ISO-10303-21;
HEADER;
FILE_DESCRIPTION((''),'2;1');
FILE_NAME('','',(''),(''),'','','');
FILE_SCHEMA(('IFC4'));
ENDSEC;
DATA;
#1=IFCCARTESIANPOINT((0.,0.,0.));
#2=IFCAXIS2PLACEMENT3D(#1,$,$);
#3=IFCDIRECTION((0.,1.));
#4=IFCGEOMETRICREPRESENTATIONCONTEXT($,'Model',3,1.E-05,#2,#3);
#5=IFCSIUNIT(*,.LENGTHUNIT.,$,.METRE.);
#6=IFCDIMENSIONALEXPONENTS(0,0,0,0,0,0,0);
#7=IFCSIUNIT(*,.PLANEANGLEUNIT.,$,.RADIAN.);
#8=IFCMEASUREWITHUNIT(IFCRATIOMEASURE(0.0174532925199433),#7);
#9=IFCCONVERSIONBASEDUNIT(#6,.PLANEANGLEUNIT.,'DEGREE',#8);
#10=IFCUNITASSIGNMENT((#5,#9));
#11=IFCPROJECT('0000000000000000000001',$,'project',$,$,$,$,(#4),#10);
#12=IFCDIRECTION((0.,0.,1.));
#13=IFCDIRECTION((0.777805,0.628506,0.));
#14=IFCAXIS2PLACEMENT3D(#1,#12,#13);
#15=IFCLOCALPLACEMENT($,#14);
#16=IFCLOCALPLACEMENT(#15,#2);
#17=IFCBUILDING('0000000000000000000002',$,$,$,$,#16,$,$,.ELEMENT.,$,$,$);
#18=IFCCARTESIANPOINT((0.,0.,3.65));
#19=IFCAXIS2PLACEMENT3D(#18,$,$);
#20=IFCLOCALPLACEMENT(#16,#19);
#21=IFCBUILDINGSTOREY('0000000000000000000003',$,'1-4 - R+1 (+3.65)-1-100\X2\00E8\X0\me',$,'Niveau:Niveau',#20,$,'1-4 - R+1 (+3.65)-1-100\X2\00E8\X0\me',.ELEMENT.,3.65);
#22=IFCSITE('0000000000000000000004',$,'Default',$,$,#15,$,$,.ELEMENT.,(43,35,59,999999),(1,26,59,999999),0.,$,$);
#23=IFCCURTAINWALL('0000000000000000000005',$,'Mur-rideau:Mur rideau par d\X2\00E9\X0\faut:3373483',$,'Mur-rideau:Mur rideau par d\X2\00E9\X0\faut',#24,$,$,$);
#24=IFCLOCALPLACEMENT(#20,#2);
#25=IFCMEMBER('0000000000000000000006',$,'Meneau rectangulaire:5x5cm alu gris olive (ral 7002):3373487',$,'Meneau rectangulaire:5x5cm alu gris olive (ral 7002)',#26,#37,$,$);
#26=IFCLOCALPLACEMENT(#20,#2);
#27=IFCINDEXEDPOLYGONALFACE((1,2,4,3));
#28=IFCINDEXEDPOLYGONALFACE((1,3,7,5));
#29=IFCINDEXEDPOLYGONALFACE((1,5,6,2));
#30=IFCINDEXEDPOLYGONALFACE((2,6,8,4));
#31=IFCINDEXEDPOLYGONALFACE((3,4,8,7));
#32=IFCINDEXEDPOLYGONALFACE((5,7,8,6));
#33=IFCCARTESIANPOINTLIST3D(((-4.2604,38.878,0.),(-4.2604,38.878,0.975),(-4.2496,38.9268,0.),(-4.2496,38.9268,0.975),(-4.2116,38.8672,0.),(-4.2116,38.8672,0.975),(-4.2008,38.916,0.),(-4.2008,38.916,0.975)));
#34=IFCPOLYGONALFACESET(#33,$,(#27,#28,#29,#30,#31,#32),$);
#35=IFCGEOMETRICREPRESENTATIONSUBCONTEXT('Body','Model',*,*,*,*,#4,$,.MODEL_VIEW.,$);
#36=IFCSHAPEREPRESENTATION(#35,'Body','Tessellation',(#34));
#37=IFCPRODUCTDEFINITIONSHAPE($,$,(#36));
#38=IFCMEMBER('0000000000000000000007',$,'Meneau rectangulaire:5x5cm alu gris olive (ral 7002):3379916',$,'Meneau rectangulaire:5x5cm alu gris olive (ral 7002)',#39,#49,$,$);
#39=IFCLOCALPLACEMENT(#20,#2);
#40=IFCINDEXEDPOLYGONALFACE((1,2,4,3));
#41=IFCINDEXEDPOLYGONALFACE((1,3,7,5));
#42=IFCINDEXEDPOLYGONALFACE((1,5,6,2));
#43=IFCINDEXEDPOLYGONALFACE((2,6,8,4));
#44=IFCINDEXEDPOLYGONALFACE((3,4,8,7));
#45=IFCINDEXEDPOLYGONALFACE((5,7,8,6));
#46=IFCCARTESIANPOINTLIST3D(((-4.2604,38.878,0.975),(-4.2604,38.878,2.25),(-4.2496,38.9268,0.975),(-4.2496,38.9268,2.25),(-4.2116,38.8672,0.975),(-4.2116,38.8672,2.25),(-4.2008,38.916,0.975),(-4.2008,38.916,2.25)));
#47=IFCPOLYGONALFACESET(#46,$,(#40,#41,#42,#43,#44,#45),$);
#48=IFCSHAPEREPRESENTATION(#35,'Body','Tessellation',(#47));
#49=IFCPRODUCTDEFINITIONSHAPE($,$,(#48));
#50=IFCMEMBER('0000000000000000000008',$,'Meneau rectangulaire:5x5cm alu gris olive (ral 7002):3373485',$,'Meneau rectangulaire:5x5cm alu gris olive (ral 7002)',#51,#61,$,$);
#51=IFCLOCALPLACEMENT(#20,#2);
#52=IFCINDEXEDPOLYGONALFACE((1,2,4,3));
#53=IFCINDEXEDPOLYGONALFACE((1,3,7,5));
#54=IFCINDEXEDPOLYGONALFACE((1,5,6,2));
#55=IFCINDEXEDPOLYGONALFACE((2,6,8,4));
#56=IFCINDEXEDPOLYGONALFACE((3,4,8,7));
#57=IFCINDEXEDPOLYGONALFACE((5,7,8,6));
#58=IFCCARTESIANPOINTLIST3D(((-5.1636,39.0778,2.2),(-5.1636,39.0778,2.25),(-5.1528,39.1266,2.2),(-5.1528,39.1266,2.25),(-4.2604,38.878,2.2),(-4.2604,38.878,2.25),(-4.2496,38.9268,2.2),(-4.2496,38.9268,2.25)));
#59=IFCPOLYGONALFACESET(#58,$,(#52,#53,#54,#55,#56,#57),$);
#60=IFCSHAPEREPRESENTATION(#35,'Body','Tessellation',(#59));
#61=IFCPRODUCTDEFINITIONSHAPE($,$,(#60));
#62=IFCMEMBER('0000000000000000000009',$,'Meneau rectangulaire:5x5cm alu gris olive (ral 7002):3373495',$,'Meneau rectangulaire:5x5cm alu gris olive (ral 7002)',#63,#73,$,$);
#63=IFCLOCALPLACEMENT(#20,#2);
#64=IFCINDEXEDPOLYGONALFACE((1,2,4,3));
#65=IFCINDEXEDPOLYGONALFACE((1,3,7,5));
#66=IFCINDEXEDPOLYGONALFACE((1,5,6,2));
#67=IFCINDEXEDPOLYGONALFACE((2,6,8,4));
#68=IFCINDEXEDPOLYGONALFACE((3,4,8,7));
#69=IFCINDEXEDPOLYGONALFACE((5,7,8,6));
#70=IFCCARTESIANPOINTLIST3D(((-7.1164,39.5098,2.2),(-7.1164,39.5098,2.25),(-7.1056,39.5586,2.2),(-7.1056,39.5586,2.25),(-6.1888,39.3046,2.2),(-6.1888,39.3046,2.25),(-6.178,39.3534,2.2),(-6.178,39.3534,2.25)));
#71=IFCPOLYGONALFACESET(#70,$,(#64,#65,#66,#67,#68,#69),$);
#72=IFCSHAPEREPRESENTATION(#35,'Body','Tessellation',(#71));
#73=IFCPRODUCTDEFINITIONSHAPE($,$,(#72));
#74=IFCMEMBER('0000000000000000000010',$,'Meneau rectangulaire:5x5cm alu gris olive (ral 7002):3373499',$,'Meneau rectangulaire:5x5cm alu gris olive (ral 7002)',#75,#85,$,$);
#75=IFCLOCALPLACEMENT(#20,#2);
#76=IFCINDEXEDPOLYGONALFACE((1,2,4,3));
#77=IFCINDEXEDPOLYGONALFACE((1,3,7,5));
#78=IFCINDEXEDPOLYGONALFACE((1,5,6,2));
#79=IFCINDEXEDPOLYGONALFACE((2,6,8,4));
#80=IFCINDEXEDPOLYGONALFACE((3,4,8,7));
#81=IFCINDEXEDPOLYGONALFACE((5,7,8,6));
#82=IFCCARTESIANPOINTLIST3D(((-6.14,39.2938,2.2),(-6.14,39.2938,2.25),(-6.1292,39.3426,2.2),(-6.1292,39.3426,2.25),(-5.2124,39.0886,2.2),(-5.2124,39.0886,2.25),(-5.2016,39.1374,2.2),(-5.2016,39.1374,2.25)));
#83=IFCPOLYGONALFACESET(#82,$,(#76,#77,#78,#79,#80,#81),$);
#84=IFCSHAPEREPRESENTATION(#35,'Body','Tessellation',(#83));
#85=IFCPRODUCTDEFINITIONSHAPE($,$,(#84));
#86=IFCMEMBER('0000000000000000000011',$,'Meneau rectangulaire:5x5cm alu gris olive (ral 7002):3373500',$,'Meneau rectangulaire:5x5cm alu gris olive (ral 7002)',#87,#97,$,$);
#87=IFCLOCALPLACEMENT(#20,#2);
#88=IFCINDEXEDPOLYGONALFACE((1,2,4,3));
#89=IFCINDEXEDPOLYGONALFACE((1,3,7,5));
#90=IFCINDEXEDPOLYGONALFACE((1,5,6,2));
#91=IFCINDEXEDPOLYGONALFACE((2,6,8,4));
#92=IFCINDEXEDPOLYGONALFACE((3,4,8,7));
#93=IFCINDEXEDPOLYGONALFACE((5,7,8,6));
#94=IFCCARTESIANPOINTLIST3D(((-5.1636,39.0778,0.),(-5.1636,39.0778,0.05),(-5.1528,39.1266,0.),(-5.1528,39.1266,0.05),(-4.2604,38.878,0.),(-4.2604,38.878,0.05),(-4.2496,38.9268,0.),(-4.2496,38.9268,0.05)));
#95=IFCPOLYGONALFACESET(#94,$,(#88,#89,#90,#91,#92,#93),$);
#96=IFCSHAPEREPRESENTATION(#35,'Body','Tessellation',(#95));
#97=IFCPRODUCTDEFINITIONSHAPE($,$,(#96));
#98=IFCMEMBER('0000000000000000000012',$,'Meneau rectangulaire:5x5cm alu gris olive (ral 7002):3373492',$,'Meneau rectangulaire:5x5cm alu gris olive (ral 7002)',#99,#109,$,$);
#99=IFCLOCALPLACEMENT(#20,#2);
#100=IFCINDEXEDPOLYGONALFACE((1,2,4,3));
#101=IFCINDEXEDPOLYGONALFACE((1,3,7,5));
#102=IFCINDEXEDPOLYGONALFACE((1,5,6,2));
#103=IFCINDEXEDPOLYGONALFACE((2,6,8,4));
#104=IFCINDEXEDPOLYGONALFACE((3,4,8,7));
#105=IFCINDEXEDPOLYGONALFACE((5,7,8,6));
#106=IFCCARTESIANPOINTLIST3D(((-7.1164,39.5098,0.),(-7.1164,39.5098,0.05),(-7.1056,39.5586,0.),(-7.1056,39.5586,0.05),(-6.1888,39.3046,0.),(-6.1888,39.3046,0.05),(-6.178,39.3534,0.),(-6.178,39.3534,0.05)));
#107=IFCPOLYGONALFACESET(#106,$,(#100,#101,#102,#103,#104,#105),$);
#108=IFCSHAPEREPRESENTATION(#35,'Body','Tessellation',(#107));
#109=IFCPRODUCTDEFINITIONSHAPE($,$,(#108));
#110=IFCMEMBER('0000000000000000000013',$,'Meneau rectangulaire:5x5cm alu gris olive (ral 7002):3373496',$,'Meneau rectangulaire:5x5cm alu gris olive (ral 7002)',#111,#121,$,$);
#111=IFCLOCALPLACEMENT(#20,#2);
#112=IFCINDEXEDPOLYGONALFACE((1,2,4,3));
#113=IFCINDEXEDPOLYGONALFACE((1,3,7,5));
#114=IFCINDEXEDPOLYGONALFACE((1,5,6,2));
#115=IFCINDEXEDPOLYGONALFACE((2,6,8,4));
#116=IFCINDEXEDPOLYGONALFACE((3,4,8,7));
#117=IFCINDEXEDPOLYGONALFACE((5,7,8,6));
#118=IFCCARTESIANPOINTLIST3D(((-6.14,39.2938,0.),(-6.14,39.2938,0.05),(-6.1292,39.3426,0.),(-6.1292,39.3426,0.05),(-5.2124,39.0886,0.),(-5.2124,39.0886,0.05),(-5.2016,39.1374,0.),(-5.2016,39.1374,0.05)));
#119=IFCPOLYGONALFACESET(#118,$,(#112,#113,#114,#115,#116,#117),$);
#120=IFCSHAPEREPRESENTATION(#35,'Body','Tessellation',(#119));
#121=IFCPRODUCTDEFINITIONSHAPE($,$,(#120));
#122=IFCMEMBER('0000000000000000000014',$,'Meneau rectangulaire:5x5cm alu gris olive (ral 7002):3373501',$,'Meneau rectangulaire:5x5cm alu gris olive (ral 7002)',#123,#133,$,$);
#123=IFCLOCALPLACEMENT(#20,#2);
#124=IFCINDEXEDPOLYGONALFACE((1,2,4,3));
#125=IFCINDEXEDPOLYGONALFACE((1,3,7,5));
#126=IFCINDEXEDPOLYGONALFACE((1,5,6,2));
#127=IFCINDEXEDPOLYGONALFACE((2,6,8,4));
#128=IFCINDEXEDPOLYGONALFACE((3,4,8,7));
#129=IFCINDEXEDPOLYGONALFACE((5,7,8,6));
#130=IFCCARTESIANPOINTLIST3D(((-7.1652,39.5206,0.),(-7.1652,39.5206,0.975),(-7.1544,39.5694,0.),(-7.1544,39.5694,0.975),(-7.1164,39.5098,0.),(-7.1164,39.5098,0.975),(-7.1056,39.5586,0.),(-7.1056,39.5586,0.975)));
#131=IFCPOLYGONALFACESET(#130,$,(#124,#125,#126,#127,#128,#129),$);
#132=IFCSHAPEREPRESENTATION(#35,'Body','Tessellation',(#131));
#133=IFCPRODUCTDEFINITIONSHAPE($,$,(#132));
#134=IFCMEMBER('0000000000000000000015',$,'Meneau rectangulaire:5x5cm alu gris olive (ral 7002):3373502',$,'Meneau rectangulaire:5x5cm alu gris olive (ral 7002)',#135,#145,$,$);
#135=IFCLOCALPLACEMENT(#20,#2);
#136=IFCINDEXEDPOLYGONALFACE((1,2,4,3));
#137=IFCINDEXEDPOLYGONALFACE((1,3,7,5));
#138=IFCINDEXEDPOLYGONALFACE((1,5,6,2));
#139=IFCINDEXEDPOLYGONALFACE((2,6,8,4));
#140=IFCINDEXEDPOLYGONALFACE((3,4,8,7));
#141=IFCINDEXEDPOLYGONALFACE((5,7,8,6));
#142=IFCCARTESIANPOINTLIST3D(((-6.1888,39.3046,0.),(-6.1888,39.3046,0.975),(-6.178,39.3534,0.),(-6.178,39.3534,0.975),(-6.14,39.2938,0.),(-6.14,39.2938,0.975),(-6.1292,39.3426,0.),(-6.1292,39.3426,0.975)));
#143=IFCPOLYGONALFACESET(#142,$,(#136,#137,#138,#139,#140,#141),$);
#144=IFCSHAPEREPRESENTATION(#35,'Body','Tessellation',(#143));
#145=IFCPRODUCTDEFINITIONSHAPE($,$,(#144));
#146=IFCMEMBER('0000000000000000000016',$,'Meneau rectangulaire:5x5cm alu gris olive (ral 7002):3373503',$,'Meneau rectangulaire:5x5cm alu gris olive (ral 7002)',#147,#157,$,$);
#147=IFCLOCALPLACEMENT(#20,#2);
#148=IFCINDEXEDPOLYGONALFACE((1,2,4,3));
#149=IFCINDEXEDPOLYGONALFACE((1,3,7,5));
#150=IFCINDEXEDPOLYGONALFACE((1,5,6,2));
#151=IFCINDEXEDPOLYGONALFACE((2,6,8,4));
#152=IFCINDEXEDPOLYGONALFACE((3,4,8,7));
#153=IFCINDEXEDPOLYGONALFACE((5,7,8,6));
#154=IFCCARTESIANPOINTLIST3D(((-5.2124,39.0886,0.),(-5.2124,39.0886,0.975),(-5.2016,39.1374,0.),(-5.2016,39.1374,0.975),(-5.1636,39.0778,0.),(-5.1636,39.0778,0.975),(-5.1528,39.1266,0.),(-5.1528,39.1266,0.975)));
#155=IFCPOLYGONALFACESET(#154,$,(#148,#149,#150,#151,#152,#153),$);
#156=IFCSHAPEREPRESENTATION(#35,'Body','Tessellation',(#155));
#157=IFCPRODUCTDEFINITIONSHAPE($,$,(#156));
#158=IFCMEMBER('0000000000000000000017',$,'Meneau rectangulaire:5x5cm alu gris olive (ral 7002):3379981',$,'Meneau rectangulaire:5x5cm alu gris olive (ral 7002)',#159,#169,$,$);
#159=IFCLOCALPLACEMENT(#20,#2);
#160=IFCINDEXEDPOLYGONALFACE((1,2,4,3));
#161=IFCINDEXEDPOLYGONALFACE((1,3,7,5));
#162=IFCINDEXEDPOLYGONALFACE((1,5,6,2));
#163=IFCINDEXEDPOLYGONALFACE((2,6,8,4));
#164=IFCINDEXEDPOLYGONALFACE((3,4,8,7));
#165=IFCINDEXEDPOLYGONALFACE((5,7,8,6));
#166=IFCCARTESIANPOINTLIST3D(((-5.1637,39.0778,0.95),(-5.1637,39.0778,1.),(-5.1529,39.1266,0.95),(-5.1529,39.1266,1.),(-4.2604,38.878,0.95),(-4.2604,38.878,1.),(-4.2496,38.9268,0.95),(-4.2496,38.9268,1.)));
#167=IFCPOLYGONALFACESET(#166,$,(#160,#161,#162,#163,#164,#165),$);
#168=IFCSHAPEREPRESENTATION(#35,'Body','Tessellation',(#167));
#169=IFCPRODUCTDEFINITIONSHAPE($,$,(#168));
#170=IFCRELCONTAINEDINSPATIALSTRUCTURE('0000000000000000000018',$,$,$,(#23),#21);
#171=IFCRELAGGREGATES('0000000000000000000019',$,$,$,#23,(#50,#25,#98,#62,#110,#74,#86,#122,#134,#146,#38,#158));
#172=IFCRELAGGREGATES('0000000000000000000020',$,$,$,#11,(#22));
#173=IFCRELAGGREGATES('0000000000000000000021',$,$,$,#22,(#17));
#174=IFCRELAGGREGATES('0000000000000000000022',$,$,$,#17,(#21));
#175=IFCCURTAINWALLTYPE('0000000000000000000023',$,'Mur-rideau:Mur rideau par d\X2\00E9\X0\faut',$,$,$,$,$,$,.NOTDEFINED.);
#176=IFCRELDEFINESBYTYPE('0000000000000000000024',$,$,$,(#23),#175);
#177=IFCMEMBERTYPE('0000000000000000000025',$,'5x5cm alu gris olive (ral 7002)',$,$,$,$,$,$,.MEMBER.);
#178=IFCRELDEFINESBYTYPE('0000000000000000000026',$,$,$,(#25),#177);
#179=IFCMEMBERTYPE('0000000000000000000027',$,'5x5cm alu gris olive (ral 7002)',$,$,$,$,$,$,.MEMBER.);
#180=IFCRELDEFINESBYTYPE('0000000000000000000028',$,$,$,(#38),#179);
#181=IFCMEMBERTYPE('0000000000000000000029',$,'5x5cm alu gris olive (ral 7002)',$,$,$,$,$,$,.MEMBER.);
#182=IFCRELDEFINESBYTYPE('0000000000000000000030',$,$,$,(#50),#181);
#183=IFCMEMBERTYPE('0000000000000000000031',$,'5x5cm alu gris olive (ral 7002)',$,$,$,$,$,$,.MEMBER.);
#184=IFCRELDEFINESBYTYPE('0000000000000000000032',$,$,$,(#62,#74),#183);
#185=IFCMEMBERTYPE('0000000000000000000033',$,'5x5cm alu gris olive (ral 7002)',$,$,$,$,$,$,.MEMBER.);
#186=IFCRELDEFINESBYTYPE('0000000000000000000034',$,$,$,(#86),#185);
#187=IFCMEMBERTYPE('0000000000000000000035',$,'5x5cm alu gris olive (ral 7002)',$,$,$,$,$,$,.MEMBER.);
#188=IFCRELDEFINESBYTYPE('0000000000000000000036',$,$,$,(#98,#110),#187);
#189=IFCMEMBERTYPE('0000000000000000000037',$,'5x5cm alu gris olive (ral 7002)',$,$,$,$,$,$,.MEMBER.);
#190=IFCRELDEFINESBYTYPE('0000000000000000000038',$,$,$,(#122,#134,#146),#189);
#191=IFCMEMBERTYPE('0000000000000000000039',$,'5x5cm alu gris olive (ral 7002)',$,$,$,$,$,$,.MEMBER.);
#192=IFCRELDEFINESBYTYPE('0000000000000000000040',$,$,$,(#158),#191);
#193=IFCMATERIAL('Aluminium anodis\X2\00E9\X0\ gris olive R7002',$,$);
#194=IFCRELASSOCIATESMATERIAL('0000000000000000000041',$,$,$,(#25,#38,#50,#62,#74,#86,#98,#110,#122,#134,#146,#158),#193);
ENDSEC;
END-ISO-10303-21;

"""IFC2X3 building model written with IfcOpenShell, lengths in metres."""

from ifc_helpers import new_model, entity, si_unit, converted_unit, direction, frame, origin, origin_2d_with_axis, place, context, subcontext, project, spatial, rectangle, extrude, source, transform, mapped, material, type_object, type_shapes, element, aggregate, save


model = new_model("IFC2X3")

# Units and contexts
model_context = context("Model", 3, precision=1e-05, world=origin(), true_north=direction((0.0, 1.0)))
body_context = subcontext(model_context, "Body", "Model", "MODEL_VIEW")
ifc_project = project(units=[si_unit("LENGTHUNIT", "METRE"), converted_unit("PLANEANGLEUNIT", "DEGREE", entity("IfcRatioMeasure", 0.0174532925199433), si_unit("PLANEANGLEUNIT", "RADIAN"), dimensions=[0, 0, 0, 0, 0, 0, 0])], contexts=[model_context])

# Site, building, storey
site_placement = place(None, frame((0.0, 0.0, 0.0), z_axis=(0.0, 0.0, 1.0), x_axis=(0.777805, 0.628506, 0.0)))
site = spatial("IfcSite", under=ifc_project, at=site_placement, Name="Default", CompositionType="ELEMENT", RefLatitude=(43, 35, 59, 999999), RefLongitude=(1, 26, 59, 999999), RefElevation=0.0)
building_placement = place(site_placement, origin())
building = spatial("IfcBuilding", under=site, at=building_placement, CompositionType="ELEMENT")
storey_placement = place(building_placement, frame((0.0, 0.0, 3.65)))
storey = spatial("IfcBuildingStorey", under=building, at=storey_placement, Name="1-4 - R+1 (+3.65)-1-100ème", ObjectType="Niveau:Niveau", LongName="1-4 - R+1 (+3.65)-1-100ème", CompositionType="ELEMENT", Elevation=3.65)

# Curtain wall, members
curtain_wall_type = type_object("IfcCurtainWallType", Name="Mur-rideau:Mur rideau par défaut", PredefinedType="NOTDEFINED")
curtain_wall_placement = place(storey_placement, frame((0.0, 0.0, -3.65)))
curtain_wall = element("IfcCurtainWall", 1, at=curtain_wall_placement, inside=storey, type_object=curtain_wall_type, Name="Mur-rideau:Mur rideau par défaut:3373483", ObjectType="Mur-rideau:Mur rideau par défaut")
ifc_material_1 = material(Name="Aluminium anodisé gris olive R7002")
member_type_1 = type_object("IfcMemberType", Name="5x5cm alu gris olive (ral 7002)", PredefinedType="MEMBER")
shared_shape_1 = source(origin(), body_context, "Body", "SweptSolid", [
    extrude(rectangle(XDim=0.05, YDim=0.05, at=origin_2d_with_axis()), frame((-0.025, 0.0, -0.975), z_axis=(0.0, 0.0, 1.0), x_axis=(0.0, -1.0, 0.0)), (0.0, 0.0, 1.0), 0.975),
])
type_shapes(member_type_1, [shared_shape_1])
member_1_placement = place(storey_placement, frame((-4.2062, 38.8916, 0.0), z_axis=(0.0, 0.0, -1.0), x_axis=(0.976392, -0.216005, 0.0)))
member_1 = element("IfcMember", 2, at=member_1_placement, type_object=member_type_1, material=ifc_material_1, Name="Meneau rectangulaire:5x5cm alu gris olive (ral 7002):3373487", ObjectType="Meneau rectangulaire:5x5cm alu gris olive (ral 7002)", context=body_context, shape_type="MappedRepresentation", body=[
    mapped(shared_shape_1, transform((0.0, 0.0, 0.0), scale=1.0)),
])
member_type_2 = type_object("IfcMemberType", Name="5x5cm alu gris olive (ral 7002)", PredefinedType="MEMBER")
shared_shape_2 = source(origin(), body_context, "Body", "SweptSolid", [
    extrude(rectangle(XDim=0.05, YDim=0.05, at=origin_2d_with_axis()), frame((-0.025, 0.0, -1.275), z_axis=(0.0, 0.0, 1.0), x_axis=(0.0, -1.0, 0.0)), (0.0, 0.0, 1.0), 1.275),
])
type_shapes(member_type_2, [shared_shape_2])
member_2_placement = place(storey_placement, frame((-4.2062, 38.8916, 0.975), z_axis=(0.0, 0.0, -1.0), x_axis=(0.976392, -0.216005, 0.0)))
member_2 = element("IfcMember", 3, at=member_2_placement, type_object=member_type_2, material=ifc_material_1, Name="Meneau rectangulaire:5x5cm alu gris olive (ral 7002):3379916", ObjectType="Meneau rectangulaire:5x5cm alu gris olive (ral 7002)", context=body_context, shape_type="MappedRepresentation", body=[
    mapped(shared_shape_2, transform((0.0, 0.0, 0.0), scale=1.0)),
])
member_type_3 = type_object("IfcMemberType", Name="5x5cm alu gris olive (ral 7002)", PredefinedType="MEMBER")
shared_shape_3 = source(origin(), body_context, "Body", "SweptSolid", [
    extrude(rectangle(XDim=0.05, YDim=0.05, at=origin_2d_with_axis()), frame((-0.025, 0.0, -0.925), z_axis=(0.0, 0.0, 1.0), x_axis=(0.0, -1.0, 0.0)), (0.0, 0.0, 1.0), 0.925),
])
type_shapes(member_type_3, [shared_shape_3])
member_3_placement = place(storey_placement, frame((-4.255, 38.9024, 2.25), z_axis=(0.976392, -0.216005, 0.0), x_axis=(0.0, 0.0, 1.0)))
member_3 = element("IfcMember", 4, at=member_3_placement, type_object=member_type_3, material=ifc_material_1, Name="Meneau rectangulaire:5x5cm alu gris olive (ral 7002):3373485", ObjectType="Meneau rectangulaire:5x5cm alu gris olive (ral 7002)", context=body_context, shape_type="MappedRepresentation", body=[
    mapped(shared_shape_3, transform((0.0, 0.0, 0.0), scale=1.0)),
])
member_type_4 = type_object("IfcMemberType", Name="5x5cm alu gris olive (ral 7002)", PredefinedType="MEMBER")
shared_shape_4 = source(origin(), body_context, "Body", "SweptSolid", [
    extrude(rectangle(XDim=0.05, YDim=0.05, at=origin_2d_with_axis()), frame((-0.025, 0.0, -0.95), z_axis=(0.0, 0.0, 1.0), x_axis=(0.0, -1.0, 0.0)), (0.0, 0.0, 1.0), 0.95),
])
type_shapes(member_type_4, [shared_shape_4])
member_4_placement = place(storey_placement, frame((-6.1834, 39.329, 2.25), z_axis=(0.976392, -0.216005, 0.0), x_axis=(0.0, 0.0, 1.0)))
member_4 = element("IfcMember", 5, at=member_4_placement, type_object=member_type_4, material=ifc_material_1, Name="Meneau rectangulaire:5x5cm alu gris olive (ral 7002):3373495", ObjectType="Meneau rectangulaire:5x5cm alu gris olive (ral 7002)", context=body_context, shape_type="MappedRepresentation", body=[
    mapped(shared_shape_4, transform((0.0, 0.0, 0.0), scale=1.0)),
])
member_5_placement = place(storey_placement, frame((-5.207, 39.113, 2.25), z_axis=(0.976392, -0.216005, 0.0), x_axis=(0.0, 0.0, 1.0)))
member_5 = element("IfcMember", 6, at=member_5_placement, type_object=member_type_4, material=ifc_material_1, Name="Meneau rectangulaire:5x5cm alu gris olive (ral 7002):3373499", ObjectType="Meneau rectangulaire:5x5cm alu gris olive (ral 7002)", context=body_context, shape_type="MappedRepresentation", body=[
    mapped(shared_shape_4, transform((0.0, 0.0, 0.0), scale=1.0)),
])
member_type_5 = type_object("IfcMemberType", Name="5x5cm alu gris olive (ral 7002)", PredefinedType="MEMBER")
shared_shape_5 = source(origin(), body_context, "Body", "SweptSolid", [
    extrude(rectangle(XDim=0.05, YDim=0.05, at=origin_2d_with_axis()), frame((-0.025, 0.0, -0.925), z_axis=(0.0, 0.0, 1.0), x_axis=(0.0, -1.0, 0.0)), (0.0, 0.0, 1.0), 0.925),
])
type_shapes(member_type_5, [shared_shape_5])
member_6_placement = place(storey_placement, frame((-5.1582, 39.1022, 0.0), z_axis=(-0.976392, 0.216005, 0.0), x_axis=(0.0, 0.0, -1.0)))
member_6 = element("IfcMember", 7, at=member_6_placement, type_object=member_type_5, material=ifc_material_1, Name="Meneau rectangulaire:5x5cm alu gris olive (ral 7002):3373500", ObjectType="Meneau rectangulaire:5x5cm alu gris olive (ral 7002)", context=body_context, shape_type="MappedRepresentation", body=[
    mapped(shared_shape_5, transform((0.0, 0.0, 0.0), scale=1.0)),
])
member_type_6 = type_object("IfcMemberType", Name="5x5cm alu gris olive (ral 7002)", PredefinedType="MEMBER")
shared_shape_6 = source(origin(), body_context, "Body", "SweptSolid", [
    extrude(rectangle(XDim=0.05, YDim=0.05, at=origin_2d_with_axis()), frame((-0.025, 0.0, -0.95), z_axis=(0.0, 0.0, 1.0), x_axis=(0.0, -1.0, 0.0)), (0.0, 0.0, 1.0), 0.95),
])
type_shapes(member_type_6, [shared_shape_6])
member_7_placement = place(storey_placement, frame((-7.111, 39.5342, 0.0), z_axis=(-0.976392, 0.216005, 0.0), x_axis=(0.0, 0.0, -1.0)))
member_7 = element("IfcMember", 8, at=member_7_placement, type_object=member_type_6, material=ifc_material_1, Name="Meneau rectangulaire:5x5cm alu gris olive (ral 7002):3373492", ObjectType="Meneau rectangulaire:5x5cm alu gris olive (ral 7002)", context=body_context, shape_type="MappedRepresentation", body=[
    mapped(shared_shape_6, transform((0.0, 0.0, 0.0), scale=1.0)),
])
member_8_placement = place(storey_placement, frame((-6.1346, 39.3182, 0.0), z_axis=(-0.976392, 0.216005, 0.0), x_axis=(0.0, 0.0, -1.0)))
member_8 = element("IfcMember", 9, at=member_8_placement, type_object=member_type_6, material=ifc_material_1, Name="Meneau rectangulaire:5x5cm alu gris olive (ral 7002):3373496", ObjectType="Meneau rectangulaire:5x5cm alu gris olive (ral 7002)", context=body_context, shape_type="MappedRepresentation", body=[
    mapped(shared_shape_6, transform((0.0, 0.0, 0.0), scale=1.0)),
])
member_type_7 = type_object("IfcMemberType", Name="5x5cm alu gris olive (ral 7002)", PredefinedType="MEMBER")
shared_shape_7 = source(origin(), body_context, "Body", "SweptSolid", [
    extrude(rectangle(XDim=0.05, YDim=0.05, at=origin_2d_with_axis()), frame((0.0, 0.0, -0.975), z_axis=(0.0, 0.0, 1.0), x_axis=(0.0, -1.0, 0.0)), (0.0, 0.0, 1.0), 0.975),
])
type_shapes(member_type_7, [shared_shape_7])
member_9_placement = place(storey_placement, frame((-7.1354, 39.5396, 0.0), z_axis=(0.0, 0.0, -1.0), x_axis=(0.976392, -0.216005, 0.0)))
member_9 = element("IfcMember", 10, at=member_9_placement, type_object=member_type_7, material=ifc_material_1, Name="Meneau rectangulaire:5x5cm alu gris olive (ral 7002):3373501", ObjectType="Meneau rectangulaire:5x5cm alu gris olive (ral 7002)", context=body_context, shape_type="MappedRepresentation", body=[
    mapped(shared_shape_7, transform((0.0, 0.0, 0.0), scale=1.0)),
])
member_10_placement = place(storey_placement, frame((-6.159, 39.3236, 0.0), z_axis=(0.0, 0.0, -1.0), x_axis=(0.976392, -0.216005, 0.0)))
member_10 = element("IfcMember", 11, at=member_10_placement, type_object=member_type_7, material=ifc_material_1, Name="Meneau rectangulaire:5x5cm alu gris olive (ral 7002):3373502", ObjectType="Meneau rectangulaire:5x5cm alu gris olive (ral 7002)", context=body_context, shape_type="MappedRepresentation", body=[
    mapped(shared_shape_7, transform((0.0, 0.0, 0.0), scale=1.0)),
])
member_11_placement = place(storey_placement, frame((-5.1826, 39.1076, 0.0), z_axis=(0.0, 0.0, -1.0), x_axis=(0.976392, -0.216005, 0.0)))
member_11 = element("IfcMember", 12, at=member_11_placement, type_object=member_type_7, material=ifc_material_1, Name="Meneau rectangulaire:5x5cm alu gris olive (ral 7002):3373503", ObjectType="Meneau rectangulaire:5x5cm alu gris olive (ral 7002)", context=body_context, shape_type="MappedRepresentation", body=[
    mapped(shared_shape_7, transform((0.0, 0.0, 0.0), scale=1.0)),
])
member_type_8 = type_object("IfcMemberType", Name="5x5cm alu gris olive (ral 7002)", PredefinedType="MEMBER")
shared_shape_8 = source(origin(), body_context, "Body", "SweptSolid", [
    extrude(rectangle(XDim=0.05, YDim=0.05, at=origin_2d_with_axis()), frame((0.0, 0.0, -0.925), z_axis=(0.0, 0.0, 1.0), x_axis=(0.0, -1.0, 0.0)), (0.0, 0.0, 1.0), 0.925),
])
type_shapes(member_type_8, [shared_shape_8])
member_12_placement = place(storey_placement, frame((-4.255, 38.9024, 0.975), z_axis=(0.976392, -0.216005, 0.0), x_axis=(0.0, 0.0, 1.0)))
member_12 = element("IfcMember", 13, at=member_12_placement, type_object=member_type_8, material=ifc_material_1, Name="Meneau rectangulaire:5x5cm alu gris olive (ral 7002):3379981", ObjectType="Meneau rectangulaire:5x5cm alu gris olive (ral 7002)", context=body_context, shape_type="MappedRepresentation", body=[
    mapped(shared_shape_8, transform((0.0, 0.0, 0.0), scale=1.0)),
])
aggregate(curtain_wall, [member_3, member_1, member_7, member_4, member_8, member_5, member_6, member_9, member_10, member_11, member_2, member_12])

save(model, "model.ifc")
